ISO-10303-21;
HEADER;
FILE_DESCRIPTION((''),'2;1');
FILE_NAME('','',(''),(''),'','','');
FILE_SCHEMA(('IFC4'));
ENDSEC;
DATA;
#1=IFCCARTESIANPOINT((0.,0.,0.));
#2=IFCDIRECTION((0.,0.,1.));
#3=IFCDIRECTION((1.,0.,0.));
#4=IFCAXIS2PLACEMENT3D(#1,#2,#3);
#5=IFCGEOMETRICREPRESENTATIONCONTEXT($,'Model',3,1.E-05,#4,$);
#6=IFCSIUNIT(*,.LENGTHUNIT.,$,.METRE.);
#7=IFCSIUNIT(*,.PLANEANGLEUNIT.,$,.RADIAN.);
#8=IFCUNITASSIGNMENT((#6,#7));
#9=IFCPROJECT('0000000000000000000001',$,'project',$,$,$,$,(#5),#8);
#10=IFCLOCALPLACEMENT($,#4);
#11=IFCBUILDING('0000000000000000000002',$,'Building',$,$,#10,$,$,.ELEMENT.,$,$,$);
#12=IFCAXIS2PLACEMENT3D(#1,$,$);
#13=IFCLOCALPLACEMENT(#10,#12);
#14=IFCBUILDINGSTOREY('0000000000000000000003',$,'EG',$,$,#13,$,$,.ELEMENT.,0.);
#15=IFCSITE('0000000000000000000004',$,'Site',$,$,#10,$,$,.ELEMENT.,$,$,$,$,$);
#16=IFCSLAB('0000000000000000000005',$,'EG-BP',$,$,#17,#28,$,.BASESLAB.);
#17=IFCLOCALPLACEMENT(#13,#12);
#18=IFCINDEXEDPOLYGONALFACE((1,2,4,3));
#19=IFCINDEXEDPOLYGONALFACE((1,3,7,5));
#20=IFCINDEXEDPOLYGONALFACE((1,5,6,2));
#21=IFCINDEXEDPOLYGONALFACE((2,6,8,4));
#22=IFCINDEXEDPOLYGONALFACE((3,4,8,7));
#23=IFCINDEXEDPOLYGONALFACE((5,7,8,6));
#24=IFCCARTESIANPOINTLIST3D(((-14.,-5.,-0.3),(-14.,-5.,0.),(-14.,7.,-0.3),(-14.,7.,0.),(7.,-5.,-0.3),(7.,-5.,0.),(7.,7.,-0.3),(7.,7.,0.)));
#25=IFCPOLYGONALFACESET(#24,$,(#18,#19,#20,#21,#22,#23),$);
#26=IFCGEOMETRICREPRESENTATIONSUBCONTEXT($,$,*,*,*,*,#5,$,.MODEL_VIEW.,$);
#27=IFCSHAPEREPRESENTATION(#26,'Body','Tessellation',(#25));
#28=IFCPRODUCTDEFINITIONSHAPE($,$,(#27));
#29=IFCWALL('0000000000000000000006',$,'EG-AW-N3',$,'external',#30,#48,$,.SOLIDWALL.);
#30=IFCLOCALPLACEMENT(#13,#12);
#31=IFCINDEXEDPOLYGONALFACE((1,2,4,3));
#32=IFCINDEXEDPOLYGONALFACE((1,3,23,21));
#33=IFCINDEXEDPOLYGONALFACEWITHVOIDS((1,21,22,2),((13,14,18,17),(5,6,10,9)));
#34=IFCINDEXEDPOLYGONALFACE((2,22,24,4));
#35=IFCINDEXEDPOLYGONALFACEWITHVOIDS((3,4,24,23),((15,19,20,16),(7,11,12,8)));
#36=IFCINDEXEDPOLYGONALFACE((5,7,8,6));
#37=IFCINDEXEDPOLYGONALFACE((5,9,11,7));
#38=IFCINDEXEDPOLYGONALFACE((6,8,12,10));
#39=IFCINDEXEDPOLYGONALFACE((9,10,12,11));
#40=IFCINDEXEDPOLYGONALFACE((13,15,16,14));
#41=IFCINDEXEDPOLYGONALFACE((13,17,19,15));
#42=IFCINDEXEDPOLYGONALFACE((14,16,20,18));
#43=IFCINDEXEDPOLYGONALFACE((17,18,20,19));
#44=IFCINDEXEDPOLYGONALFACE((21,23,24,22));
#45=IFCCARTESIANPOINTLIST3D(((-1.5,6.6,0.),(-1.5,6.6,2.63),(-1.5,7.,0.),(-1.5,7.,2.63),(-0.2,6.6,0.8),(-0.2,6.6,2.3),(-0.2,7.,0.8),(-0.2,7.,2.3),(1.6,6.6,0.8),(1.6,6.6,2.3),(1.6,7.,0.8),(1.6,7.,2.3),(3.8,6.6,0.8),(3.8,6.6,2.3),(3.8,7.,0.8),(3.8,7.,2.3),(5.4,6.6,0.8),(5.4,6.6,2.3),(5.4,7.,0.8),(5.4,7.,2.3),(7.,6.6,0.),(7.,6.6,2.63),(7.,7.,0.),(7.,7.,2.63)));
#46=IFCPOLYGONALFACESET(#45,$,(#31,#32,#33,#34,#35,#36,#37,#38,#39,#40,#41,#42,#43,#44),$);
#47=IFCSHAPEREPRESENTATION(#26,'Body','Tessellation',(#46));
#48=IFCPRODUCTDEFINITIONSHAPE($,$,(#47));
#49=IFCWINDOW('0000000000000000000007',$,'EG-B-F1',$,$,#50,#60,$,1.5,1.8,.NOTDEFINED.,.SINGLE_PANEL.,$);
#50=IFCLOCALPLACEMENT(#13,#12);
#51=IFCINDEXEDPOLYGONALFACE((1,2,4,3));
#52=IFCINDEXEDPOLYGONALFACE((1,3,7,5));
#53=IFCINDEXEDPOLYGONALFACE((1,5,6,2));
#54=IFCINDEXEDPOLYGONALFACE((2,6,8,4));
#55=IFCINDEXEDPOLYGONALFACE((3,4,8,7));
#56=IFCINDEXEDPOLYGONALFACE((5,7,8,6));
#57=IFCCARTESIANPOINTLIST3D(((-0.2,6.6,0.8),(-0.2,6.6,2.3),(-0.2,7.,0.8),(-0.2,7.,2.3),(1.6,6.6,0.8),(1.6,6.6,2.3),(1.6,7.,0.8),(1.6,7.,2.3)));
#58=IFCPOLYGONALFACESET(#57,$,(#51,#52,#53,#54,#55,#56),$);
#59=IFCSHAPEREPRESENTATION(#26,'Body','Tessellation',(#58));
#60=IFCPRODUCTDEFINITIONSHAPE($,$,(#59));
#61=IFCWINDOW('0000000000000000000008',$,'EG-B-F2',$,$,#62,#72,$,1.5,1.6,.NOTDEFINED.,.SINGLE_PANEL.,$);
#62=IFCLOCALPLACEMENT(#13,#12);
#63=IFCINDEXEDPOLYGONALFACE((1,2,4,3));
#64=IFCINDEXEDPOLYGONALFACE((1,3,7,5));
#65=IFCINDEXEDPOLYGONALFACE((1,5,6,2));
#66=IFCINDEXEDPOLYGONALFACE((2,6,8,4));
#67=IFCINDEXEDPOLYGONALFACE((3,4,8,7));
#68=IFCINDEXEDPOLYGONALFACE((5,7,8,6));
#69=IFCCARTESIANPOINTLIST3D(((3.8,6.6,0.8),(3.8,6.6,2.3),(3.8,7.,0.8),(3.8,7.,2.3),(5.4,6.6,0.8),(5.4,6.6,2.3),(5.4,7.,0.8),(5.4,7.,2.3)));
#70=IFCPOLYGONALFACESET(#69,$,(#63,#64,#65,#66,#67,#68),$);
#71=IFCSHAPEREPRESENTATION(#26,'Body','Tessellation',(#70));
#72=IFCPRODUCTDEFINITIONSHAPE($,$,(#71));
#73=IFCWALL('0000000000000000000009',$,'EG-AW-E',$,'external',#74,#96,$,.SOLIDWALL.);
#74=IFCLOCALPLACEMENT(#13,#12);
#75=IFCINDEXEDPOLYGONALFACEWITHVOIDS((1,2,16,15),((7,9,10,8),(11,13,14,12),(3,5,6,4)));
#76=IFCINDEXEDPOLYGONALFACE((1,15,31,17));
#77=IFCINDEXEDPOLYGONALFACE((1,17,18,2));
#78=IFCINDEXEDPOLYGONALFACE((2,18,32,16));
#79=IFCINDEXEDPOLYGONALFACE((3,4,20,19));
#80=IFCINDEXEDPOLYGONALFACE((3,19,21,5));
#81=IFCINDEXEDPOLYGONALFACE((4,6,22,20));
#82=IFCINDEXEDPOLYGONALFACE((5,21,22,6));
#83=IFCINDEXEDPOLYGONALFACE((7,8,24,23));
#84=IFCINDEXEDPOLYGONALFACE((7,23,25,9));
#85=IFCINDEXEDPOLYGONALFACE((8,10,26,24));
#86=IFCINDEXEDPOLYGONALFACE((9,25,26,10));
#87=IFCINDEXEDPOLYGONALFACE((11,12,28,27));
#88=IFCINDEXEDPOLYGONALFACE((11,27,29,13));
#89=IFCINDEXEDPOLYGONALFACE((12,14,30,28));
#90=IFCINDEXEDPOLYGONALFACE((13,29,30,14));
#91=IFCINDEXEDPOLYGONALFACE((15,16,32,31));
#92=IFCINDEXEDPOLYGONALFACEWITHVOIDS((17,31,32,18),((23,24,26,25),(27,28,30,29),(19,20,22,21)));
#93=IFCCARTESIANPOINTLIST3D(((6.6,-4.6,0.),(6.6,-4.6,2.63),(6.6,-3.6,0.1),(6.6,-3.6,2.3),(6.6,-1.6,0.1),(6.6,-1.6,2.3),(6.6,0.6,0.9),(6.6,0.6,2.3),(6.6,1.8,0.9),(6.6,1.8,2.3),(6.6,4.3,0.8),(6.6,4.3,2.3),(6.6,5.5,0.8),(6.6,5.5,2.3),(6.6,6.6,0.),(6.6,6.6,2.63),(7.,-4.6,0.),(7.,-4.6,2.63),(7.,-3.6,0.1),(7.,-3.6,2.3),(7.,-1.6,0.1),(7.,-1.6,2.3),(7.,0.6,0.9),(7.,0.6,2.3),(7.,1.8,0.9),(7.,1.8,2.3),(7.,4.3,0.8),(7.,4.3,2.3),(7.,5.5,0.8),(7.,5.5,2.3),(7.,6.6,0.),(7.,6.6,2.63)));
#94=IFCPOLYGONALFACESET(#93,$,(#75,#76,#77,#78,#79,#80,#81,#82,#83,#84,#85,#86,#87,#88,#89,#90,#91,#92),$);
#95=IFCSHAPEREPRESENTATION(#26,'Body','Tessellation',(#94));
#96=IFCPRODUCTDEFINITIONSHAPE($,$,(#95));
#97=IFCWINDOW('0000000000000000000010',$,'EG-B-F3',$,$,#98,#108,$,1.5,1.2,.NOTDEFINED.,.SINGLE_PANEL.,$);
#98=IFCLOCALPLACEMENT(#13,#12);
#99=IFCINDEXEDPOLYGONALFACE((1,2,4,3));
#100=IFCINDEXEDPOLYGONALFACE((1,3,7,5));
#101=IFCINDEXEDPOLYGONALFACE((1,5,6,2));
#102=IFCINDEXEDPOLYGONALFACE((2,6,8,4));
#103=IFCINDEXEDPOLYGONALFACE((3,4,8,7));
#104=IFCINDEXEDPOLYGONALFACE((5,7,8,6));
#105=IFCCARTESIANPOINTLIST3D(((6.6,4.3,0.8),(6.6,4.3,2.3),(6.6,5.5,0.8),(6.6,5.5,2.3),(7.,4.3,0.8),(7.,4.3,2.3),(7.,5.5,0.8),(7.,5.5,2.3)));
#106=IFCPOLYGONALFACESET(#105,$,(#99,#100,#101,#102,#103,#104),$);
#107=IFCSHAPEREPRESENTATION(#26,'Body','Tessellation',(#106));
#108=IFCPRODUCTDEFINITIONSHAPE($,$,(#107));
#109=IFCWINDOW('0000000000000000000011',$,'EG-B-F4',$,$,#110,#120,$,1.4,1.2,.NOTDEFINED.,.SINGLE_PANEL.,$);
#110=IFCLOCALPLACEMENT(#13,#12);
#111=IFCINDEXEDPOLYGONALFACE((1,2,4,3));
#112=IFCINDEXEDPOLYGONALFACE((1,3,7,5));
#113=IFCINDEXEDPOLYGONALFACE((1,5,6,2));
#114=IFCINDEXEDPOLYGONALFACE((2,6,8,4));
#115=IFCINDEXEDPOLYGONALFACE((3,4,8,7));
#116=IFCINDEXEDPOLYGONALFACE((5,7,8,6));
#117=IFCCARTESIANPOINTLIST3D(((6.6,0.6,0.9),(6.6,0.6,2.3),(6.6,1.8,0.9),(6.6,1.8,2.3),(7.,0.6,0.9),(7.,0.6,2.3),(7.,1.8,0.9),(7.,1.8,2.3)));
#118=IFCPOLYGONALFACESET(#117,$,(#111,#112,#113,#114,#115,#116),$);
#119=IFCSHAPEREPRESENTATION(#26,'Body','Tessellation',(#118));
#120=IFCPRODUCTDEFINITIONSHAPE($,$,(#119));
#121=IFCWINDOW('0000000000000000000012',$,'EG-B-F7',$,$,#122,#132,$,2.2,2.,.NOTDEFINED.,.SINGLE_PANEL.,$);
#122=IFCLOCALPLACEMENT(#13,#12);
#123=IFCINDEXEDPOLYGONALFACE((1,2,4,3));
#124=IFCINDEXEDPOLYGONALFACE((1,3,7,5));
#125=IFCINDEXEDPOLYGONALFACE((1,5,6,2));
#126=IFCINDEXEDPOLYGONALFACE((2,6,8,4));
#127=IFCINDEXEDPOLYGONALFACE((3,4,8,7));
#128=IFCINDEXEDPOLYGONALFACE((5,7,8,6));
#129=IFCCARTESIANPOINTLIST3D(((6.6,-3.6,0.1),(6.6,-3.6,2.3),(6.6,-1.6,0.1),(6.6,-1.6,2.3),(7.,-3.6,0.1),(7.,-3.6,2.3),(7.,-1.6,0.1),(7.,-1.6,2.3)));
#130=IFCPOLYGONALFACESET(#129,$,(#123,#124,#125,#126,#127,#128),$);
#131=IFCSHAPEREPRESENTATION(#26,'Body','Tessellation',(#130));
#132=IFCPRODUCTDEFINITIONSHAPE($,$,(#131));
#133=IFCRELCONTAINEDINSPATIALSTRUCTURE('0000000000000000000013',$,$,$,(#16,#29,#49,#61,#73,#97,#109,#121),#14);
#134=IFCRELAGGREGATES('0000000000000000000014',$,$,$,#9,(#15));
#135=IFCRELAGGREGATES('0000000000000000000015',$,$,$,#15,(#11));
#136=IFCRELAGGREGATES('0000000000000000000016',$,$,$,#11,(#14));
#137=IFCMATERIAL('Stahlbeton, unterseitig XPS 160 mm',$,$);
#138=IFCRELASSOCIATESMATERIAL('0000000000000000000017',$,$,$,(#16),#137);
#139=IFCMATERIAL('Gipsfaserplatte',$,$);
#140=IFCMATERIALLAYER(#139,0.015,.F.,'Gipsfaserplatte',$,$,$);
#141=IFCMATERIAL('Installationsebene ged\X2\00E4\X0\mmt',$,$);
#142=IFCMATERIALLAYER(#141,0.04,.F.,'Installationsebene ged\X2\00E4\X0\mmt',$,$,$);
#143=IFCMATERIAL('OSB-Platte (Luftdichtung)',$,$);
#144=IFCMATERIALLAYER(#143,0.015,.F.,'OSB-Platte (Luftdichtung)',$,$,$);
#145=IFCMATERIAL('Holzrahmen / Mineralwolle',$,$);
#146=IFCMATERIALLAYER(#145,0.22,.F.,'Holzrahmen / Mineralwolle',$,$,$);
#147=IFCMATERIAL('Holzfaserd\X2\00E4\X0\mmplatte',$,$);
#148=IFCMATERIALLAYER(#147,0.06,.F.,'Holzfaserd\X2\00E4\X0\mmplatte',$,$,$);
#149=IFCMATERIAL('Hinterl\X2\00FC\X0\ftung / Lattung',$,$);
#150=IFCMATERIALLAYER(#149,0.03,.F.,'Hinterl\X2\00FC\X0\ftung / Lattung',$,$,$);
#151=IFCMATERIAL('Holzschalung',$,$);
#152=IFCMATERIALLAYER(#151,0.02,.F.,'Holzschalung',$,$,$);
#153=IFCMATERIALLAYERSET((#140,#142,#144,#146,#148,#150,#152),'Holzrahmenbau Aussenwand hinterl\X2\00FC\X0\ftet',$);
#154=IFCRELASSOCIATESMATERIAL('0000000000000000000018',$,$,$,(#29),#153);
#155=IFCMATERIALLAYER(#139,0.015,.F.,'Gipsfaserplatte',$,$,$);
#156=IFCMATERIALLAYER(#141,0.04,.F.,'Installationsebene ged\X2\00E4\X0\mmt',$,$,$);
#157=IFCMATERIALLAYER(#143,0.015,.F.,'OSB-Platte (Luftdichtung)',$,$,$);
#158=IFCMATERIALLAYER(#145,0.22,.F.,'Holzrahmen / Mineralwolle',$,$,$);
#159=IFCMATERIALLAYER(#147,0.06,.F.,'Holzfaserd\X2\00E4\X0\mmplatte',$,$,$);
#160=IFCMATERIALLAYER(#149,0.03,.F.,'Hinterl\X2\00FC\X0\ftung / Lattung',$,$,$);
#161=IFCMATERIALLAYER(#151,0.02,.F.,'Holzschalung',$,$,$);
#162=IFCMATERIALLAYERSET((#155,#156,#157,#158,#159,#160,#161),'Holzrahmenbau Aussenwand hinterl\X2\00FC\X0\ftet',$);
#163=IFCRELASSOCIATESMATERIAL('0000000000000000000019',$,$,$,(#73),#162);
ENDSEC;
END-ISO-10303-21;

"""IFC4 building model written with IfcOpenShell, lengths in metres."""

from ifc_helpers import new_model, si_unit, frame, frame_2d, origin, origin_with_axes, place, context, subcontext, project, spatial, polyline, rectangle, outline, extrude, material, layer, layer_set, element, fill, save


model = new_model("IFC4")

# Units and contexts
model_context = context("Model", 3, precision=1e-05, world=origin_with_axes())
sub_context = subcontext(model_context, None, None, "MODEL_VIEW")
ifc_project = project(units=[si_unit("LENGTHUNIT", "METRE"), si_unit("PLANEANGLEUNIT", "RADIAN")], contexts=[model_context])

# Site, building, storey
placement = place(None, origin_with_axes())
site = spatial("IfcSite", under=ifc_project, at=placement, Name="Site", CompositionType="ELEMENT")
building = spatial("IfcBuilding", under=site, at=placement, Name="Building", CompositionType="ELEMENT")
storey_placement = place(placement, origin())
storey = spatial("IfcBuildingStorey", under=building, at=storey_placement, Name="EG", CompositionType="ELEMENT", Elevation=0.0)

# Slab
ifc_material_1 = material(Name="Stahlbeton, unterseitig XPS 160 mm")
slab_placement = place(storey_placement, frame((0.0, 0.0, -0.3)))
element("IfcSlab", 1, at=slab_placement, inside=storey, material=ifc_material_1, Name="EG-BP", PredefinedType="BASESLAB", context=sub_context, shape_type="SweptSolid", body=[
    extrude(outline(polyline([(-14.0, -5.0), (7.0, -5.0), (7.0, 7.0), (-14.0, 7.0), (-14.0, -5.0)])), origin(), (0.0, 0.0, 1.0), 0.3),
])

# Walls, openings, windows
ifc_material_2 = material(Name="Gipsfaserplatte")
ifc_layer_1 = layer(ifc_material_2, 0.015, ventilated=False, Name="Gipsfaserplatte")
ifc_material_3 = material(Name="Installationsebene gedämmt")
ifc_layer_2 = layer(ifc_material_3, 0.04, ventilated=False, Name="Installationsebene gedämmt")
ifc_material_4 = material(Name="OSB-Platte (Luftdichtung)")
ifc_layer_3 = layer(ifc_material_4, 0.015, ventilated=False, Name="OSB-Platte (Luftdichtung)")
ifc_material_5 = material(Name="Holzrahmen / Mineralwolle")
ifc_layer_4 = layer(ifc_material_5, 0.22, ventilated=False, Name="Holzrahmen / Mineralwolle")
ifc_material_6 = material(Name="Holzfaserdämmplatte")
ifc_layer_5 = layer(ifc_material_6, 0.06, ventilated=False, Name="Holzfaserdämmplatte")
ifc_material_7 = material(Name="Hinterlüftung / Lattung")
ifc_layer_6 = layer(ifc_material_7, 0.03, ventilated=False, Name="Hinterlüftung / Lattung")
ifc_material_8 = material(Name="Holzschalung")
ifc_layer_7 = layer(ifc_material_8, 0.02, ventilated=False, Name="Holzschalung")
ifc_layer_set_1 = layer_set([ifc_layer_1, ifc_layer_2, ifc_layer_3, ifc_layer_4, ifc_layer_5, ifc_layer_6, ifc_layer_7], Name="Holzrahmenbau Aussenwand hinterlüftet")
wall_1_placement = place(storey_placement, frame((-1.5, 6.8, 0.0), z_axis=(0.0, 0.0, 1.0), x_axis=(1.0, 0.0, 0.0)))
wall_1 = element("IfcWall", 2, at=wall_1_placement, inside=storey, material=ifc_layer_set_1, Name="EG-AW-N3", ObjectType="external", PredefinedType="SOLIDWALL", context=sub_context, shape_type="SweptSolid", body=[
    extrude(rectangle(XDim=8.5, YDim=0.4, at=frame_2d((4.25, 0.0))), origin(), (0.0, 0.0, 1.0), 2.63),
])
opening_1_placement = place(wall_1_placement, frame((2.2, 0.25, 0.8), z_axis=(0.0, -1.0, 0.0), x_axis=(1.0, 0.0, 0.0)))
opening_1 = element("IfcOpeningElement", 3, at=opening_1_placement, cuts=wall_1, PredefinedType="OPENING", context=sub_context, shape_type="SweptSolid", body=[
    extrude(rectangle(XDim=1.8, YDim=1.5, at=frame_2d((0.0, 0.75))), origin(), (0.0, 0.0, 1.0), 0.5),
])
opening_2_placement = place(wall_1_placement, frame((6.1, 0.25, 0.8), z_axis=(0.0, -1.0, 0.0), x_axis=(1.0, 0.0, 0.0)))
opening_2 = element("IfcOpeningElement", 4, at=opening_2_placement, cuts=wall_1, PredefinedType="OPENING", context=sub_context, shape_type="SweptSolid", body=[
    extrude(rectangle(XDim=1.6, YDim=1.5, at=frame_2d((0.0, 0.75))), origin(), (0.0, 0.0, 1.0), 0.5),
])
window_1_placement = place(wall_1_placement, frame((2.2, 0.2, 0.8), z_axis=(0.0, -1.0, 0.0), x_axis=(1.0, 0.0, 0.0)))
window_1 = element("IfcWindow", 5, at=window_1_placement, inside=storey, Name="EG-B-F1", OverallHeight=1.5, OverallWidth=1.8, PartitioningType="SINGLE_PANEL", PredefinedType="NOTDEFINED", context=sub_context, shape_type="SweptSolid", body=[
    extrude(rectangle(XDim=1.8, YDim=1.5, at=frame_2d((0.0, 0.75))), origin(), (0.0, 0.0, 1.0), 0.4),
])
fill(opening_1, window_1)
window_2_placement = place(wall_1_placement, frame((6.1, 0.2, 0.8), z_axis=(0.0, -1.0, 0.0), x_axis=(1.0, 0.0, 0.0)))
window_2 = element("IfcWindow", 6, at=window_2_placement, inside=storey, Name="EG-B-F2", OverallHeight=1.5, OverallWidth=1.6, PartitioningType="SINGLE_PANEL", PredefinedType="NOTDEFINED", context=sub_context, shape_type="SweptSolid", body=[
    extrude(rectangle(XDim=1.6, YDim=1.5, at=frame_2d((0.0, 0.75))), origin(), (0.0, 0.0, 1.0), 0.4),
])
fill(opening_2, window_2)
ifc_layer_8 = layer(ifc_material_2, 0.015, ventilated=False, Name="Gipsfaserplatte")
ifc_layer_9 = layer(ifc_material_3, 0.04, ventilated=False, Name="Installationsebene gedämmt")
ifc_layer_10 = layer(ifc_material_4, 0.015, ventilated=False, Name="OSB-Platte (Luftdichtung)")
ifc_layer_11 = layer(ifc_material_5, 0.22, ventilated=False, Name="Holzrahmen / Mineralwolle")
ifc_layer_12 = layer(ifc_material_6, 0.06, ventilated=False, Name="Holzfaserdämmplatte")
ifc_layer_13 = layer(ifc_material_7, 0.03, ventilated=False, Name="Hinterlüftung / Lattung")
ifc_layer_14 = layer(ifc_material_8, 0.02, ventilated=False, Name="Holzschalung")
ifc_layer_set_2 = layer_set([ifc_layer_8, ifc_layer_9, ifc_layer_10, ifc_layer_11, ifc_layer_12, ifc_layer_13, ifc_layer_14], Name="Holzrahmenbau Aussenwand hinterlüftet")
wall_2_placement = place(storey_placement, frame((6.8, 6.6, 0.0), z_axis=(0.0, 0.0, 1.0), x_axis=(0.0, -1.0, 0.0)))
wall_2 = element("IfcWall", 7, at=wall_2_placement, inside=storey, material=ifc_layer_set_2, Name="EG-AW-E", ObjectType="external", PredefinedType="SOLIDWALL", context=sub_context, shape_type="SweptSolid", body=[
    extrude(rectangle(XDim=11.2, YDim=0.4, at=frame_2d((5.6, 0.0))), origin(), (0.0, 0.0, 1.0), 2.63),
])
opening_3_placement = place(wall_2_placement, frame((1.7, 0.25, 0.8), z_axis=(0.0, -1.0, 0.0), x_axis=(1.0, 0.0, 0.0)))
opening_3 = element("IfcOpeningElement", 8, at=opening_3_placement, cuts=wall_2, PredefinedType="OPENING", context=sub_context, shape_type="SweptSolid", body=[
    extrude(rectangle(XDim=1.2, YDim=1.5, at=frame_2d((0.0, 0.75))), origin(), (0.0, 0.0, 1.0), 0.5),
])
opening_4_placement = place(wall_2_placement, frame((5.4, 0.25, 0.9), z_axis=(0.0, -1.0, 0.0), x_axis=(1.0, 0.0, 0.0)))
opening_4 = element("IfcOpeningElement", 9, at=opening_4_placement, cuts=wall_2, PredefinedType="OPENING", context=sub_context, shape_type="SweptSolid", body=[
    extrude(rectangle(XDim=1.2, YDim=1.4, at=frame_2d((0.0, 0.7))), origin(), (0.0, 0.0, 1.0), 0.5),
])
opening_5_placement = place(wall_2_placement, frame((9.2, 0.25, 0.1), z_axis=(0.0, -1.0, 0.0), x_axis=(1.0, 0.0, 0.0)))
opening_5 = element("IfcOpeningElement", 10, at=opening_5_placement, cuts=wall_2, PredefinedType="OPENING", context=sub_context, shape_type="SweptSolid", body=[
    extrude(rectangle(XDim=2.0, YDim=2.2, at=frame_2d((0.0, 1.1))), origin(), (0.0, 0.0, 1.0), 0.5),
])
window_3_placement = place(wall_2_placement, frame((1.7, 0.2, 0.8), z_axis=(0.0, -1.0, 0.0), x_axis=(1.0, 0.0, 0.0)))
window_3 = element("IfcWindow", 11, at=window_3_placement, inside=storey, Name="EG-B-F3", OverallHeight=1.5, OverallWidth=1.2, PartitioningType="SINGLE_PANEL", PredefinedType="NOTDEFINED", context=sub_context, shape_type="SweptSolid", body=[
    extrude(rectangle(XDim=1.2, YDim=1.5, at=frame_2d((0.0, 0.75))), origin(), (0.0, 0.0, 1.0), 0.4),
])
fill(opening_3, window_3)
window_4_placement = place(wall_2_placement, frame((5.4, 0.2, 0.9), z_axis=(0.0, -1.0, 0.0), x_axis=(1.0, 0.0, 0.0)))
window_4 = element("IfcWindow", 12, at=window_4_placement, inside=storey, Name="EG-B-F4", OverallHeight=1.4, OverallWidth=1.2, PartitioningType="SINGLE_PANEL", PredefinedType="NOTDEFINED", context=sub_context, shape_type="SweptSolid", body=[
    extrude(rectangle(XDim=1.2, YDim=1.4, at=frame_2d((0.0, 0.7))), origin(), (0.0, 0.0, 1.0), 0.4),
])
fill(opening_4, window_4)
window_5_placement = place(wall_2_placement, frame((9.2, 0.2, 0.1), z_axis=(0.0, -1.0, 0.0), x_axis=(1.0, 0.0, 0.0)))
window_5 = element("IfcWindow", 13, at=window_5_placement, inside=storey, Name="EG-B-F7", OverallHeight=2.2, OverallWidth=2.0, PartitioningType="SINGLE_PANEL", PredefinedType="NOTDEFINED", context=sub_context, shape_type="SweptSolid", body=[
    extrude(rectangle(XDim=2.0, YDim=2.2, at=frame_2d((0.0, 1.1))), origin(), (0.0, 0.0, 1.0), 0.4),
])
fill(opening_5, window_5)

save(model, "model.ifc")
